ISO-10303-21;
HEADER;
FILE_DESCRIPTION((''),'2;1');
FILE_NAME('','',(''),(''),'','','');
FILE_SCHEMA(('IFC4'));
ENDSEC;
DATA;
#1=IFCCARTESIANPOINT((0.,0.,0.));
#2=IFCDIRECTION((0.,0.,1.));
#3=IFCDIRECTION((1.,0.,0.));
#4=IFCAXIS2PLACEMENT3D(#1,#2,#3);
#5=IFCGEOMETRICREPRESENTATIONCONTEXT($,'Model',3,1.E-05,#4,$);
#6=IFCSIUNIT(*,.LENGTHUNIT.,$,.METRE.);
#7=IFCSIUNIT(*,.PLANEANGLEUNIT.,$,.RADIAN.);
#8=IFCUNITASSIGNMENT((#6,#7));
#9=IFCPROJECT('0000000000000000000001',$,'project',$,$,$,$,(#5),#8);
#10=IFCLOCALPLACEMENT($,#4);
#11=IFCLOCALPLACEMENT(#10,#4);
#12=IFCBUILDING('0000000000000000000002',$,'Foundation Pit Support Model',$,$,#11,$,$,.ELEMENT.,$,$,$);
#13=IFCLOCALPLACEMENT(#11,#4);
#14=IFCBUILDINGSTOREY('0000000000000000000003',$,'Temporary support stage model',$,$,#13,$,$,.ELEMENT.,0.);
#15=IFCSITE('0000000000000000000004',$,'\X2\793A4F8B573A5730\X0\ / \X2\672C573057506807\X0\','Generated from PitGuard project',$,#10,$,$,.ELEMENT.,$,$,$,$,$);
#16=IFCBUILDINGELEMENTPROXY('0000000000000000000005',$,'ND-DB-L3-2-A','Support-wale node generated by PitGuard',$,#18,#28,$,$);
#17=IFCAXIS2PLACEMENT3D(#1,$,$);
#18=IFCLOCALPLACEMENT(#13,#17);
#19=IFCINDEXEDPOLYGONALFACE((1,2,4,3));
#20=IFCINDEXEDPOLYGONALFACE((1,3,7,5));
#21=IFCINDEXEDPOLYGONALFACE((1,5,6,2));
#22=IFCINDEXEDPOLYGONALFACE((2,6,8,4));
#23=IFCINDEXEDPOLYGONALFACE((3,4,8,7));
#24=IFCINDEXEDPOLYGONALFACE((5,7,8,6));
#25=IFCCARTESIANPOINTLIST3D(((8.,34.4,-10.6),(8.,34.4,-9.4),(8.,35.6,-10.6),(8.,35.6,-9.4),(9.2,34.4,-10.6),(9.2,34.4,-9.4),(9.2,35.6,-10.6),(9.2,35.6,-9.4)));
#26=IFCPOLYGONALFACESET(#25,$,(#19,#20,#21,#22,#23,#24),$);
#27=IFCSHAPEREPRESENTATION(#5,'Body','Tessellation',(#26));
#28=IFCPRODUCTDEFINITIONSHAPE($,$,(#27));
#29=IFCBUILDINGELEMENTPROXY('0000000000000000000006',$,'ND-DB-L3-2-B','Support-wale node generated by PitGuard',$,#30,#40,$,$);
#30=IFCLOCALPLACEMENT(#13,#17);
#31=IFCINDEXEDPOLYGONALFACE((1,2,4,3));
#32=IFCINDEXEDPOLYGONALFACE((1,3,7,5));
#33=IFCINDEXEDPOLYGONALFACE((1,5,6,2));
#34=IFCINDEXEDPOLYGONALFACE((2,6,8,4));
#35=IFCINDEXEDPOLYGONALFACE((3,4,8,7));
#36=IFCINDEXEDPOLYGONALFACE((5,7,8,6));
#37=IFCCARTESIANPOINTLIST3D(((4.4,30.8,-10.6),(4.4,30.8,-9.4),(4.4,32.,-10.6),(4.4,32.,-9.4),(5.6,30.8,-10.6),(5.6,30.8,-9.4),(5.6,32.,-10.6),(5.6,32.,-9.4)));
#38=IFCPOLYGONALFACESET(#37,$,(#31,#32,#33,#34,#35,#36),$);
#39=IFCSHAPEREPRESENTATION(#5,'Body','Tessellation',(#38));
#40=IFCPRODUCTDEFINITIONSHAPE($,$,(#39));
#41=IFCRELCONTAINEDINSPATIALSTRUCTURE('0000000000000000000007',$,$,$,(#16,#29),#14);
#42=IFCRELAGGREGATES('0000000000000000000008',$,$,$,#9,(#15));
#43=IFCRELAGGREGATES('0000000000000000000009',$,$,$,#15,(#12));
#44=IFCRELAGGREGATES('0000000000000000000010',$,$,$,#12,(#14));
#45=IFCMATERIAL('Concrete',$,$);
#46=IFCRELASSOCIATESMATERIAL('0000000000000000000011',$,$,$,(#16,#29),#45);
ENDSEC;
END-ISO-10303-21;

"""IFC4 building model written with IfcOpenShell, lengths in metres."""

from ifc_helpers import new_model, si_unit, frame, origin_with_axes, origin_2d, place, context, project, spatial, rectangle, extrude, material, element, save


model = new_model("IFC4")

# Units and contexts
model_context = context("Model", 3, precision=1e-05, world=origin_with_axes())
ifc_project = project(units=[si_unit("LENGTHUNIT", "METRE"), si_unit("PLANEANGLEUNIT", "RADIAN")], contexts=[model_context])

# Site, building, storey
site_placement = place(None, origin_with_axes())
site = spatial("IfcSite", under=ifc_project, at=site_placement, Name="示例场地 / 本地坐标", Description="Generated from PitGuard project", CompositionType="ELEMENT")
building_placement = place(site_placement, origin_with_axes())
building = spatial("IfcBuilding", under=site, at=building_placement, Name="Foundation Pit Support Model", CompositionType="ELEMENT")
storey_placement = place(building_placement, origin_with_axes())
storey = spatial("IfcBuildingStorey", under=building, at=storey_placement, Name="Temporary support stage model", CompositionType="ELEMENT", Elevation=0.0)

# Shared definitions
ifc_material_1 = material(Name="Concrete")

# Building element proxies
for number, where, z_axis, x_axis, name in (
    (1, (8.6, 35.0, -10.6), (0.0, 0.0, 1.0), (1.0, 0.0, 0.0), "ND-DB-L3-2-A"),
    (2, (5.0, 31.4, -10.6), (0.0, 0.0, 1.0), (1.0, 0.0, 0.0), "ND-DB-L3-2-B"),
):
    element("IfcBuildingElementProxy", number, at=place(storey_placement, frame(where, z_axis=z_axis, x_axis=x_axis)), inside=storey, material=ifc_material_1, Name=name, Description="Support-wale node generated by PitGuard", context=model_context, shape_type="SweptSolid", body=[
        extrude(rectangle(XDim=1.2, YDim=1.2, at=origin_2d()), origin_with_axes(), (0.0, 0.0, 1.0), 1.2),
    ])

save(model, "model.ifc")
